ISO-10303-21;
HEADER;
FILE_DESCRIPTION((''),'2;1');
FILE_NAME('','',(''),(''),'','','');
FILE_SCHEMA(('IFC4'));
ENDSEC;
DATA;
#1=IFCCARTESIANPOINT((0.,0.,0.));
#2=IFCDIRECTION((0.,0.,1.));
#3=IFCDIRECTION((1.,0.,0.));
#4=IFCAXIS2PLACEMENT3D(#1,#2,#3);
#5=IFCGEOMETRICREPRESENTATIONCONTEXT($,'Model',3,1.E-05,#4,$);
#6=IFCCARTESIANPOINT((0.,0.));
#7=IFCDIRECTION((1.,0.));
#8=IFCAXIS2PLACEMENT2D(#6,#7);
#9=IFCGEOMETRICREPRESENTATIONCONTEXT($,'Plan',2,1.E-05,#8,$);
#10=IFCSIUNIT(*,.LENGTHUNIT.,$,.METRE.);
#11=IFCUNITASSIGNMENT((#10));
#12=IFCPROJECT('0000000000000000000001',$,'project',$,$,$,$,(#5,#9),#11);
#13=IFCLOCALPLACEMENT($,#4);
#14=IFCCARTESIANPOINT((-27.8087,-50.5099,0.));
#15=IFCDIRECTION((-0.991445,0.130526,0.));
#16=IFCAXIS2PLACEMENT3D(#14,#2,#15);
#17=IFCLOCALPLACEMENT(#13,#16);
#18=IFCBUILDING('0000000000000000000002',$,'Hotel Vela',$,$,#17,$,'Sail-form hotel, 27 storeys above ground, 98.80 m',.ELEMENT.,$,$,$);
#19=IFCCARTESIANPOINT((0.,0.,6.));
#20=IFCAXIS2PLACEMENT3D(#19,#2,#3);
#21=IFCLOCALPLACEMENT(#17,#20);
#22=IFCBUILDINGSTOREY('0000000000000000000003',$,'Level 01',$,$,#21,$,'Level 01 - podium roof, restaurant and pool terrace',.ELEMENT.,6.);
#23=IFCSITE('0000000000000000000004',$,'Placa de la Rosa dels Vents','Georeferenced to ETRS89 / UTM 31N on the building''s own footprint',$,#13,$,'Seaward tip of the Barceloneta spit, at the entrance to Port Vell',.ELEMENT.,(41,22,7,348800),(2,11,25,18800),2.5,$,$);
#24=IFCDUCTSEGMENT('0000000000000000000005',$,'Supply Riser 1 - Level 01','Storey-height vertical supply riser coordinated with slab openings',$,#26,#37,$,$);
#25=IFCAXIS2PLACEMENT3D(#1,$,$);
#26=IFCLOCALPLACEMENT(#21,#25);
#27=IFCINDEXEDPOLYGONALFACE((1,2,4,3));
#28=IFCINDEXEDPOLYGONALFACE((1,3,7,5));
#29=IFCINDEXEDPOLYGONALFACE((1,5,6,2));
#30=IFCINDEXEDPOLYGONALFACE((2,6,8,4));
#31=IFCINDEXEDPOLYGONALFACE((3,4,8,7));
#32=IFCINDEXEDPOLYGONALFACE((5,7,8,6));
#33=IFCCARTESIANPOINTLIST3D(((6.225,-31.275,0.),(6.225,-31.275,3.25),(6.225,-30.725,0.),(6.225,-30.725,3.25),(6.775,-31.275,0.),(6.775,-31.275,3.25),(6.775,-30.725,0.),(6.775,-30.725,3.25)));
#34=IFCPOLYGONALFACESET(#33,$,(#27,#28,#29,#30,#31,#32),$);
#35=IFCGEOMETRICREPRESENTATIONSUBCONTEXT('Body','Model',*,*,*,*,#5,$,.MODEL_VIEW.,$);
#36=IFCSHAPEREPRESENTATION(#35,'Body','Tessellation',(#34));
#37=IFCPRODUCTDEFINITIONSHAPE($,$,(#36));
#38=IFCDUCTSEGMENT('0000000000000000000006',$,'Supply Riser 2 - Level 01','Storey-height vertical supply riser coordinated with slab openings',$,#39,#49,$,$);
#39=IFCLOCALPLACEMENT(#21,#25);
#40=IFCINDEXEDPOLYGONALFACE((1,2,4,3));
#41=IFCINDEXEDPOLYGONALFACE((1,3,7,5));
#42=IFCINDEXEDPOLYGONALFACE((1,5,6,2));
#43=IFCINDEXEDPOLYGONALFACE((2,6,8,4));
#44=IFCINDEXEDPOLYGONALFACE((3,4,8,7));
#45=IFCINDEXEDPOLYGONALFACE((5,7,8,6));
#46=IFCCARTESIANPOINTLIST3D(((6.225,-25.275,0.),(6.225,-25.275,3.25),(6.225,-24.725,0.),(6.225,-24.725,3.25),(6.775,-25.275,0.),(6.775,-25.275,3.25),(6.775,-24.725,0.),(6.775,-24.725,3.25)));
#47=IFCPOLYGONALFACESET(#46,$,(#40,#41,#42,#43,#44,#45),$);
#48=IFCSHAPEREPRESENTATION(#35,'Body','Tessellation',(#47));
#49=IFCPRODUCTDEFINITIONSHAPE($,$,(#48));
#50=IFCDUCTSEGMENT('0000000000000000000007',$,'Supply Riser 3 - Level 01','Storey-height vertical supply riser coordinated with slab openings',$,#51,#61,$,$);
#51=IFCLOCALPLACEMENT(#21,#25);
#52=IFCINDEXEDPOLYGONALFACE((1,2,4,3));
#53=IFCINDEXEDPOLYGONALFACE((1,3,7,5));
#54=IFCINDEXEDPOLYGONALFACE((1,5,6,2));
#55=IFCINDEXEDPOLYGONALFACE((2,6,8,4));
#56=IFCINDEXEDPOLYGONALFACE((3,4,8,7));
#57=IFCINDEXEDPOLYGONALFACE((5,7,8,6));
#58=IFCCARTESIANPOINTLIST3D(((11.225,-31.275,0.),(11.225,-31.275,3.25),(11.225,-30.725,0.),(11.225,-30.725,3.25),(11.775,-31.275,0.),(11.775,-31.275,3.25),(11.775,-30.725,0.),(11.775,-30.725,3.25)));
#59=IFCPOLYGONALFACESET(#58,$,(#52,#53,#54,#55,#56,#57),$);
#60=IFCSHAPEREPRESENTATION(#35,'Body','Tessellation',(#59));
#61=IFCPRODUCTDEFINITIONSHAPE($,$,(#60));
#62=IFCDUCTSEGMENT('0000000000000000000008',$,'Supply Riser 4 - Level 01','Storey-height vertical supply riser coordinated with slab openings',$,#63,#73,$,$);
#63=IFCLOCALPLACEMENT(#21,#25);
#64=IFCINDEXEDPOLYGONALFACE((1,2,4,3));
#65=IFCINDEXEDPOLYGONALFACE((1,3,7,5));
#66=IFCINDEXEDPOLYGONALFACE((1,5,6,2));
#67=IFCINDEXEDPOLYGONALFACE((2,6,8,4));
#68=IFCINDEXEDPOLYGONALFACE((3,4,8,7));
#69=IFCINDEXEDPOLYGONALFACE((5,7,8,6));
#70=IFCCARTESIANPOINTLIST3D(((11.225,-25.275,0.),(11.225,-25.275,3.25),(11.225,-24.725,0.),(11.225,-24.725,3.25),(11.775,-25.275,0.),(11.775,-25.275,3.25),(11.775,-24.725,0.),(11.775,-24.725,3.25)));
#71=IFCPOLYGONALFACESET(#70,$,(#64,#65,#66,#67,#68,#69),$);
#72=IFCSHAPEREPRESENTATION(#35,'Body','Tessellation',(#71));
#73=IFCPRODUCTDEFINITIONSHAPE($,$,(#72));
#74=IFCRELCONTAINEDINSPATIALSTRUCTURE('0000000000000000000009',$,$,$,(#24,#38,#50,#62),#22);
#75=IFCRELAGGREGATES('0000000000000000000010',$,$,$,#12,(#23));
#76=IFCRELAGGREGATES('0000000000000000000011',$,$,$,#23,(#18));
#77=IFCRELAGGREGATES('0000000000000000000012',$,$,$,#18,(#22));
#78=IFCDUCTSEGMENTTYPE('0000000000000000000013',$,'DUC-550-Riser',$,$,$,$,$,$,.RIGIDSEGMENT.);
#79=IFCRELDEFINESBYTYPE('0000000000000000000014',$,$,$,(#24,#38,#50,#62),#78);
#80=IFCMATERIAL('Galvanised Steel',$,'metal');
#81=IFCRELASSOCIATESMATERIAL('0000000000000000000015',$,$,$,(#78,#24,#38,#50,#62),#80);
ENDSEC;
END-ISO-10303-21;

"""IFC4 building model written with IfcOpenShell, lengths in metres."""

from ifc_helpers import new_model, si_unit, frame, origin_with_axes, origin_2d_with_axis, place, context, subcontext, project, spatial, line, indexed_curve, outline, extrude, material, type_object, element, save


model = new_model("IFC4")

# Units and contexts
model_context = context("Model", 3, precision=1e-05, world=origin_with_axes())
plan_context = context("Plan", 2, precision=1e-05, world=origin_2d_with_axis())
body_context = subcontext(model_context, "Body", "Model", "MODEL_VIEW")
ifc_project = project(units=[si_unit("LENGTHUNIT", "METRE")], contexts=[model_context, plan_context])

# Site, building, storey
site_placement = place(None, origin_with_axes())
site = spatial("IfcSite", under=ifc_project, at=site_placement, Name="Placa de la Rosa dels Vents", Description="Georeferenced to ETRS89 / UTM 31N on the building's own footprint", LongName="Seaward tip of the Barceloneta spit, at the entrance to Port Vell", CompositionType="ELEMENT", RefLatitude=(41, 22, 7, 348800), RefLongitude=(2, 11, 25, 18800), RefElevation=2.5)
building_placement = place(site_placement, frame((-27.8087, -50.5099, 0.0), z_axis=(0.0, 0.0, 1.0), x_axis=(-0.991445, 0.130526, 0.0)))
building = spatial("IfcBuilding", under=site, at=building_placement, Name="Hotel Vela", LongName="Sail-form hotel, 27 storeys above ground, 98.80 m", CompositionType="ELEMENT")
storey_placement = place(building_placement, frame((0.0, 0.0, 6.0), z_axis=(0.0, 0.0, 1.0), x_axis=(1.0, 0.0, 0.0)))
storey = spatial("IfcBuildingStorey", under=building, at=storey_placement, Name="Level 01", LongName="Level 01 - podium roof, restaurant and pool terrace", CompositionType="ELEMENT", Elevation=6.0)

# Duct segments
ifc_material = material(Name="Galvanised Steel", Category="metal")
duct_segment_type = type_object("IfcDuctSegmentType", Name="DUC-550-Riser", PredefinedType="RIGIDSEGMENT", material=ifc_material)
for number, where, z_axis, x_axis, name in (
    (1, (6.225, -31.275, 0.0), (0.0, 0.0, 1.0), (1.0, 0.0, 0.0), "Supply Riser 1 - Level 01"),
    (2, (6.225, -25.275, 0.0), (0.0, 0.0, 1.0), (1.0, 0.0, 0.0), "Supply Riser 2 - Level 01"),
    (3, (11.225, -31.275, 0.0), (0.0, 0.0, 1.0), (1.0, 0.0, 0.0), "Supply Riser 3 - Level 01"),
    (4, (11.225, -25.275, 0.0), (0.0, 0.0, 1.0), (1.0, 0.0, 0.0), "Supply Riser 4 - Level 01"),
):
    element("IfcDuctSegment", number, at=place(storey_placement, frame(where, z_axis=z_axis, x_axis=x_axis)), inside=storey, type_object=duct_segment_type, material=ifc_material, Name=name, Description="Storey-height vertical supply riser coordinated with slab openings", context=body_context, shape_type="SweptSolid", body=[
        extrude(outline(indexed_curve([(0.0, 0.0), (0.55, 0.0), (0.55, 0.55), (0.0, 0.55)], segments=[line(1, 2, 3, 4, 1)])), origin_with_axes(), (0.0, 0.0, 1.0), 3.25),
    ])

save(model, "model.ifc")
